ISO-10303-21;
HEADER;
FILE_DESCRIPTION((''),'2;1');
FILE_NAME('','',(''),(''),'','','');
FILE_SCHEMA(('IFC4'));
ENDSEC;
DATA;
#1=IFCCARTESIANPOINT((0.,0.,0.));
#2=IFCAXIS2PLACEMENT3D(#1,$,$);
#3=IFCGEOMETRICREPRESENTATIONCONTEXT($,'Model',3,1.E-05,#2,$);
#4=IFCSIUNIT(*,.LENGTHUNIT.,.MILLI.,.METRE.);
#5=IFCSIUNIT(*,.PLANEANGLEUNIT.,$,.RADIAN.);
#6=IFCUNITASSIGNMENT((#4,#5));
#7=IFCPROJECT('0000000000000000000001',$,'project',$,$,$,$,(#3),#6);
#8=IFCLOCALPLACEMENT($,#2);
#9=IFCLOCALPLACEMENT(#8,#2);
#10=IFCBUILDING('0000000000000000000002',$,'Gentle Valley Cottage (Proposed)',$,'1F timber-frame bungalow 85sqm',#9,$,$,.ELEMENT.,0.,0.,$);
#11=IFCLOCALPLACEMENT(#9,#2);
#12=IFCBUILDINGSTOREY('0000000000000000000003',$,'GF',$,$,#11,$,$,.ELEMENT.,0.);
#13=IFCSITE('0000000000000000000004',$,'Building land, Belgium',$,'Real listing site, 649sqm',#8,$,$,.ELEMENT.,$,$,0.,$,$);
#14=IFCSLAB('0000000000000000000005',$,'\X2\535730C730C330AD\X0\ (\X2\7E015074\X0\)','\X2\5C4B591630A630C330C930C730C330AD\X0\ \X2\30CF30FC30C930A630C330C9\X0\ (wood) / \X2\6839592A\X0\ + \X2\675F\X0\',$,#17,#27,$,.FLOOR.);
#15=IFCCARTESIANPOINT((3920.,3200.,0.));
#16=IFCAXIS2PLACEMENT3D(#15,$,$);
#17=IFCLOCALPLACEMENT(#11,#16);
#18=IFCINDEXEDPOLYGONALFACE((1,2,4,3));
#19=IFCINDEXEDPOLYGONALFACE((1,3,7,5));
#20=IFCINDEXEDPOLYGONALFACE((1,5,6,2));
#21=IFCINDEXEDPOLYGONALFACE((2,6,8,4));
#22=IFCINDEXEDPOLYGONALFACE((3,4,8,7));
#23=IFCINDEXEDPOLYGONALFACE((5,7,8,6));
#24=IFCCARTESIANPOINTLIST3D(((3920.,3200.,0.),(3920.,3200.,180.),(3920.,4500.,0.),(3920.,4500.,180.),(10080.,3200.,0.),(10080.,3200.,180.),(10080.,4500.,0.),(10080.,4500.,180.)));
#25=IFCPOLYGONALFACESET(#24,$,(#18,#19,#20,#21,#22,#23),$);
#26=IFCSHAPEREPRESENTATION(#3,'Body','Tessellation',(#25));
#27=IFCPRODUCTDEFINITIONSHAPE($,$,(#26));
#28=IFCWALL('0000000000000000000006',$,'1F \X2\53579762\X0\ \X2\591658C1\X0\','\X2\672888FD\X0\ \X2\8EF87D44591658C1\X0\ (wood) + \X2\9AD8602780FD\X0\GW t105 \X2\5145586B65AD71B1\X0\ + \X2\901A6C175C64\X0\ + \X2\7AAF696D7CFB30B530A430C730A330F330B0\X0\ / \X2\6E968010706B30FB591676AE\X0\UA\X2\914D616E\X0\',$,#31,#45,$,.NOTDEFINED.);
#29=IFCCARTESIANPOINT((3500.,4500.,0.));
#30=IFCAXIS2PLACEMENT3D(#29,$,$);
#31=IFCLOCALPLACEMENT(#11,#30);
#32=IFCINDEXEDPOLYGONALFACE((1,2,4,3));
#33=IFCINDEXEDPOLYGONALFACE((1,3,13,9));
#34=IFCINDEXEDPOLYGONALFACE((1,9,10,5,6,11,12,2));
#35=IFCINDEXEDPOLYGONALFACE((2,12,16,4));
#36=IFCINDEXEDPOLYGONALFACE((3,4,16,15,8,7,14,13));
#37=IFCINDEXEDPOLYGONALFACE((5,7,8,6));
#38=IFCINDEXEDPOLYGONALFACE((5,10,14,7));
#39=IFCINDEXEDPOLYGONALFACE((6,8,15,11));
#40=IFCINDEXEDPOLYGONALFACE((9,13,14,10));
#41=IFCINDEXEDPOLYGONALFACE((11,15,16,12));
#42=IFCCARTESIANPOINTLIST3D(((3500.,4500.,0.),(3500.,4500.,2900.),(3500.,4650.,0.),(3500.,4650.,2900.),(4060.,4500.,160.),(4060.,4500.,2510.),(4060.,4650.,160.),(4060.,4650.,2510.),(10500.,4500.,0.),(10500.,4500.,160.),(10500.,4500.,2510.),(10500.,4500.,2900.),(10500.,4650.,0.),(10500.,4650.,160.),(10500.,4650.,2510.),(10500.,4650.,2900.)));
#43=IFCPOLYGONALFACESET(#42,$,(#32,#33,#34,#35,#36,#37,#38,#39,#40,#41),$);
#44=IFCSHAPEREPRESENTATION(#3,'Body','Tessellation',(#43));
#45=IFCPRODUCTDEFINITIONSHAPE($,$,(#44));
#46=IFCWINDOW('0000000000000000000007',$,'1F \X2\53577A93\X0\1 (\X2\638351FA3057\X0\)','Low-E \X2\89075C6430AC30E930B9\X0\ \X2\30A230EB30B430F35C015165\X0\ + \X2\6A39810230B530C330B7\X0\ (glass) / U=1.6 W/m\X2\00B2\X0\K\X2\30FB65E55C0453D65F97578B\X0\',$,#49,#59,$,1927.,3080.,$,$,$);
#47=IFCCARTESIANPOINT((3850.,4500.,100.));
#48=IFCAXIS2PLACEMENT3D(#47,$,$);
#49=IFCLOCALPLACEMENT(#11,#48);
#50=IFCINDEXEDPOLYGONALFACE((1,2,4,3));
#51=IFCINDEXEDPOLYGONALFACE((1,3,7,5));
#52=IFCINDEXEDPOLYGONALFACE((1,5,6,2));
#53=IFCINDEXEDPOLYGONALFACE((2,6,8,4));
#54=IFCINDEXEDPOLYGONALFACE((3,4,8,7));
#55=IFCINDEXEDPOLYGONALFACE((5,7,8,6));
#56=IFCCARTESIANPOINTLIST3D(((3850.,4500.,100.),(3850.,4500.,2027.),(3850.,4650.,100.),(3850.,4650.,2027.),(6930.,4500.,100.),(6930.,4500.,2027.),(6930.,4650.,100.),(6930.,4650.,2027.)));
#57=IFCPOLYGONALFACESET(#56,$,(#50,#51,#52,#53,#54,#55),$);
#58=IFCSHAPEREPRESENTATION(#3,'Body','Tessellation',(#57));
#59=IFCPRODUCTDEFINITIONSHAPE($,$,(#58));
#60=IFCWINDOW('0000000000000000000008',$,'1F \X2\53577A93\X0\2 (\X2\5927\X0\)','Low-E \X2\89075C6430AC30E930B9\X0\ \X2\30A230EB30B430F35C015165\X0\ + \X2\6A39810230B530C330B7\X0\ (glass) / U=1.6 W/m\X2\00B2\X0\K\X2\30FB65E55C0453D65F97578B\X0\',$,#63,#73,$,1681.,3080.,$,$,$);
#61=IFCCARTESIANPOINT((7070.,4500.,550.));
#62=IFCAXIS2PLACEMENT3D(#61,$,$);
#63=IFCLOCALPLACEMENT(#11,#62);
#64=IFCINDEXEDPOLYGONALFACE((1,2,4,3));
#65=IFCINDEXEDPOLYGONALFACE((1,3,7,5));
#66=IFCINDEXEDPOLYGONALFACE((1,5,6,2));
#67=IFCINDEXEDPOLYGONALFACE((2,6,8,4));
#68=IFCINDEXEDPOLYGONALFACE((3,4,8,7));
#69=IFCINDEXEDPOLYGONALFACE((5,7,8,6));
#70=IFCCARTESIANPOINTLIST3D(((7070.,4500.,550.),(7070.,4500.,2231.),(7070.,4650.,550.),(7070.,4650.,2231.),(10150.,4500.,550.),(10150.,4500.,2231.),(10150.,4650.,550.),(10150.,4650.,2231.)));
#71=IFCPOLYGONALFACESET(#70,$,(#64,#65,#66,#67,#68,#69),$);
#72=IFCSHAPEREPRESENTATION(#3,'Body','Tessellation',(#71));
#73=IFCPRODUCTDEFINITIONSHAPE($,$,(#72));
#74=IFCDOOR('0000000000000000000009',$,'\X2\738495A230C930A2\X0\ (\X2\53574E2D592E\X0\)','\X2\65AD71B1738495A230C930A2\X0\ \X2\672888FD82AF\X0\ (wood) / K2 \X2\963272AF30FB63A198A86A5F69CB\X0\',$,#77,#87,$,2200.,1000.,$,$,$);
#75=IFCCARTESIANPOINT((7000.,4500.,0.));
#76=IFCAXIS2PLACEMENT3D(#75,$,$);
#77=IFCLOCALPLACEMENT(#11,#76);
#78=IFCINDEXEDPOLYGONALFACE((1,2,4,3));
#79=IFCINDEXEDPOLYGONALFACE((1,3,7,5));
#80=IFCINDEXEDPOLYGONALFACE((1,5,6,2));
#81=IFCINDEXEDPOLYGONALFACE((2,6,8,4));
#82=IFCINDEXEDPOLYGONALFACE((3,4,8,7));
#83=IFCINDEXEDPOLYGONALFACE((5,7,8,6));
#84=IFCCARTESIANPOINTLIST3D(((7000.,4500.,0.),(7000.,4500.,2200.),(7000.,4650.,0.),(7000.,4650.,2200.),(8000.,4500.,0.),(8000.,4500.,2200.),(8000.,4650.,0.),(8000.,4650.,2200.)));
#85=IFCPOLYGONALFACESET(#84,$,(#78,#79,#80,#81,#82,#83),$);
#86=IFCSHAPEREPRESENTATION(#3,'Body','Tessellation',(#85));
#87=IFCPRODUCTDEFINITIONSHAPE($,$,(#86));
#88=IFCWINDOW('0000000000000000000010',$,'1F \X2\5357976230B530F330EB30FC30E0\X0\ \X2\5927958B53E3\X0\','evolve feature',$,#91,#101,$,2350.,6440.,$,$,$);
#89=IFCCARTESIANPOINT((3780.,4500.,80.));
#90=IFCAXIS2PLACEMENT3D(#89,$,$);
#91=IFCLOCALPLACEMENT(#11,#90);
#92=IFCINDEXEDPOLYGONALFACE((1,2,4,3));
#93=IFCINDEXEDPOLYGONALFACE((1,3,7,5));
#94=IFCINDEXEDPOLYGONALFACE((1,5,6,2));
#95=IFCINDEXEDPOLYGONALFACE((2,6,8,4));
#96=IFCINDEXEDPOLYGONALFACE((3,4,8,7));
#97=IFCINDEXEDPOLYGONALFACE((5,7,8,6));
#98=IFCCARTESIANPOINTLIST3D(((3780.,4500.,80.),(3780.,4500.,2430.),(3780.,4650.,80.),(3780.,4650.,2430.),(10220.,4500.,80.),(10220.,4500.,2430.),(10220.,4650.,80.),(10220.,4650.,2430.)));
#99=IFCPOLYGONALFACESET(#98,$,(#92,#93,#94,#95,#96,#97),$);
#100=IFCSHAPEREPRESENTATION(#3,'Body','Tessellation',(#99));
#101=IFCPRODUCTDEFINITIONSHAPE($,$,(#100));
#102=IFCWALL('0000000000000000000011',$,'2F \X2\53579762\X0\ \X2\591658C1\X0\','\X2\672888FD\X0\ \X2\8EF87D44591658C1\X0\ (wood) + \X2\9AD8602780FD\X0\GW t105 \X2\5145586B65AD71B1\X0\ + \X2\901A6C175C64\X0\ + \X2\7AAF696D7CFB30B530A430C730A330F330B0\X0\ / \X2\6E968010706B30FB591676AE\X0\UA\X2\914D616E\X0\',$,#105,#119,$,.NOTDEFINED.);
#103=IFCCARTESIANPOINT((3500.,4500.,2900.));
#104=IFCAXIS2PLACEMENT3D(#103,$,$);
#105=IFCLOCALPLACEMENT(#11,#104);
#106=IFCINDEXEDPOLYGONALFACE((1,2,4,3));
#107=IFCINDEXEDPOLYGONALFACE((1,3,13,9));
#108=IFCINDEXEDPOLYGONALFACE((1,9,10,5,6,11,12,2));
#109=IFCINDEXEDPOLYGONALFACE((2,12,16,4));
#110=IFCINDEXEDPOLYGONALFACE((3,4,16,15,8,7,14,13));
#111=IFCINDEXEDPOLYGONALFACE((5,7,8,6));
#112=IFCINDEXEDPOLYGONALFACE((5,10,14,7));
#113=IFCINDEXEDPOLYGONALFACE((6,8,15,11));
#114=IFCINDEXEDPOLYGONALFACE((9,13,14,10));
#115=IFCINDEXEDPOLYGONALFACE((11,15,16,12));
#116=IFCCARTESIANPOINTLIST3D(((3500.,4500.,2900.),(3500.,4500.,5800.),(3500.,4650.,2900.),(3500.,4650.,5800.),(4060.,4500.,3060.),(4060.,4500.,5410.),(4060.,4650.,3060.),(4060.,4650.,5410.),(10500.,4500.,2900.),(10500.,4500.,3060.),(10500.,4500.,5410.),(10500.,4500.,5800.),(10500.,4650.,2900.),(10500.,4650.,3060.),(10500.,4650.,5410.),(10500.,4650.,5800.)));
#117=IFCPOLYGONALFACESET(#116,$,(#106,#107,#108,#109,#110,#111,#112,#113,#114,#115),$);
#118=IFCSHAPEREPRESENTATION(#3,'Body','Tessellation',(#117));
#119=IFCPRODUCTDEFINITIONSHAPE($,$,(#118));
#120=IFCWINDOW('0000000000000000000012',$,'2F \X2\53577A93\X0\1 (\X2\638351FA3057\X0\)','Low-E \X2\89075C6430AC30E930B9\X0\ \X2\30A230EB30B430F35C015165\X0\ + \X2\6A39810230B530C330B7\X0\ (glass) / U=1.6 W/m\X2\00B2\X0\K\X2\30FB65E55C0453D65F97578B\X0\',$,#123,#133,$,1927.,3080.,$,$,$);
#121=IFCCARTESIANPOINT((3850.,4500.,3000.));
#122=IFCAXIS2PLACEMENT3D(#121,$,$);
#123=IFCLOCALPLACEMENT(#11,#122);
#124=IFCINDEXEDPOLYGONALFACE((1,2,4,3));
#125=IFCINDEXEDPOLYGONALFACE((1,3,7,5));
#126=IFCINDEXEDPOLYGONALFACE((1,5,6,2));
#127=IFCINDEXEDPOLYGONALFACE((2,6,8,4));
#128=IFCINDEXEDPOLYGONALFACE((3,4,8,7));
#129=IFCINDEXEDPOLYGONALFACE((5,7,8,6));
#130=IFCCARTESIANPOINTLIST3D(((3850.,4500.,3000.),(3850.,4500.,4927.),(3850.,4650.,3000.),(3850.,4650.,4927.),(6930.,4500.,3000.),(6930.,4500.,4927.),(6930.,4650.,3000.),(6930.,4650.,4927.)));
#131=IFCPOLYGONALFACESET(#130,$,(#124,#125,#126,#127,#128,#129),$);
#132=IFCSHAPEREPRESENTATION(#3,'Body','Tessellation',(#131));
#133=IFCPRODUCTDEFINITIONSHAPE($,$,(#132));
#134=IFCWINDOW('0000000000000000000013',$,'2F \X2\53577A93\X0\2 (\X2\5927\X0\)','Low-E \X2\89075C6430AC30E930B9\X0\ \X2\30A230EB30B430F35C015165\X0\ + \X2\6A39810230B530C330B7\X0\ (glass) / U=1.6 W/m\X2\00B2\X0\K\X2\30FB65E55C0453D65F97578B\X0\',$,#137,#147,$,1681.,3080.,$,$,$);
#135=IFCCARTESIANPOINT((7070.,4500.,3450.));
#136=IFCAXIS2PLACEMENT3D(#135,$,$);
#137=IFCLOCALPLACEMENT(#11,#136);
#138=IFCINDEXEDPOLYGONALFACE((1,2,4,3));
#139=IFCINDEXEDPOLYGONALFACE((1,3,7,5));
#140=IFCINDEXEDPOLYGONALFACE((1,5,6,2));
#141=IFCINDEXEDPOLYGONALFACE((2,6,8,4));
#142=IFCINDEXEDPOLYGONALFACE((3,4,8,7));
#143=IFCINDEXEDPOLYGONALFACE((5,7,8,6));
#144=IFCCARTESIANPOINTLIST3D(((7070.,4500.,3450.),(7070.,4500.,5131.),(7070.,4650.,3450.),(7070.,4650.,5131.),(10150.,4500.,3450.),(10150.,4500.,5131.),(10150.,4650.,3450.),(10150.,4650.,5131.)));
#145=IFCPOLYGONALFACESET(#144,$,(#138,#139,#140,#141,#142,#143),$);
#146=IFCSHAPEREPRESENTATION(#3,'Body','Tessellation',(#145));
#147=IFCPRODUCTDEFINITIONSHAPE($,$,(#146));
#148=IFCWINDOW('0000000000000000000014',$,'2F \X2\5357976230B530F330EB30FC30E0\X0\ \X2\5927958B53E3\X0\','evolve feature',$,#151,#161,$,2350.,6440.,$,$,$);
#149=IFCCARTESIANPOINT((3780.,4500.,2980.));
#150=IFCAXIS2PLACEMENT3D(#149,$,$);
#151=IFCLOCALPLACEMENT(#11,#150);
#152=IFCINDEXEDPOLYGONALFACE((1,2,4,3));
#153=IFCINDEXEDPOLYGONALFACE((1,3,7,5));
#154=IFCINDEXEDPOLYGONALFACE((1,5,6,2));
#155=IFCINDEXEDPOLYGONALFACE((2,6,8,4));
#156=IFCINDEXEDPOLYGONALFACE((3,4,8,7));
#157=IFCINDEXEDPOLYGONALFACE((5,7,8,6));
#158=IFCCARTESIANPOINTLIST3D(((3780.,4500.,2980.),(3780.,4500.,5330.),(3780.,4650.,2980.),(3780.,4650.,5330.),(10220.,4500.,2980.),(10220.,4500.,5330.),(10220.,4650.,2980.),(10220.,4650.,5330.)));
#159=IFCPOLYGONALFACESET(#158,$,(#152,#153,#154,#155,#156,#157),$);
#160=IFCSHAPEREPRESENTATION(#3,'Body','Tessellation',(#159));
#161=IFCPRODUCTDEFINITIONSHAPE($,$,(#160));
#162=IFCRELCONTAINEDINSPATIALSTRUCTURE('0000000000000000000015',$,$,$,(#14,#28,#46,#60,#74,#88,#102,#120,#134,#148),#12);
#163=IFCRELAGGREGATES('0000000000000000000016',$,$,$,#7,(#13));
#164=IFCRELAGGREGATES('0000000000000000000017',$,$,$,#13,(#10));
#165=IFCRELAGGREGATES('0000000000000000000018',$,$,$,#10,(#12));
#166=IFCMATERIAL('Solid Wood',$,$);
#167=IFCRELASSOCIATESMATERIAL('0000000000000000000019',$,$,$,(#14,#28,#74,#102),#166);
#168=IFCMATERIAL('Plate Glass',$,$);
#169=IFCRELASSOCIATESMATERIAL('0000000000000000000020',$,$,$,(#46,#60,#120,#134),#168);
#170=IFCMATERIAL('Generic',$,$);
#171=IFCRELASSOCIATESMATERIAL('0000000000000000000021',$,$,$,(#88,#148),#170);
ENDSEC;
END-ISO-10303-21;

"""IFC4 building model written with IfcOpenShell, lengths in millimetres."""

from ifc_helpers import new_model, si_unit, frame, frame_2d, origin, place, context, project, spatial, rectangle, extrude, material, element, fill, save


model = new_model("IFC4")

# Units and contexts
model_context = context("Model", 3, precision=1e-05, world=origin())
ifc_project = project(units=[si_unit("LENGTHUNIT", "METRE", prefix="MILLI"), si_unit("PLANEANGLEUNIT", "RADIAN")], contexts=[model_context])

# Site, building, storey
site_placement = place(None, origin())
site = spatial("IfcSite", under=ifc_project, at=site_placement, Name="Building land, Belgium", ObjectType="Real listing site, 649sqm", CompositionType="ELEMENT", RefElevation=0.0)
building_placement = place(site_placement, origin())
building = spatial("IfcBuilding", under=site, at=building_placement, Name="Gentle Valley Cottage (Proposed)", ObjectType="1F timber-frame bungalow 85sqm", CompositionType="ELEMENT", ElevationOfRefHeight=0.0, ElevationOfTerrain=0.0)
storey_placement = place(building_placement, origin())
storey = spatial("IfcBuildingStorey", under=building, at=storey_placement, Name="GF", CompositionType="ELEMENT", Elevation=0.0)

# Slab
ifc_material_1 = material(Name="Solid Wood")
slab_1_placement = place(storey_placement, frame((3920.0, 3200.0, 0.0)))
element("IfcSlab", 1, at=slab_1_placement, inside=storey, material=ifc_material_1, Name="南デッキ (縁側)", Description="屋外ウッドデッキ ハードウッド (wood) / 根太 + 束", PredefinedType="FLOOR", context=model_context, shape_type="SweptSolid", body=[
    extrude(rectangle(XDim=6160.0, YDim=1300.0, at=frame_2d((3080.0, 650.0))), frame((3920.0, 3200.0, 0.0)), (0.0, 0.0, 1.0), 180.0),
])
ifc_material_2 = material(Name="Generic")

# Wall, openings, windows, door
wall_1_placement = place(storey_placement, frame((3500.0, 4500.0, 0.0)))
wall_1 = element("IfcWall", 2, at=wall_1_placement, inside=storey, material=ifc_material_1, Name="1F 南面 外壁", Description="木製 軸組外壁 (wood) + 高性能GW t105 充填断熱 + 通気層 + 窯業系サイディング / 準耐火・外皮UA配慮", PredefinedType="NOTDEFINED", context=model_context, shape_type="SweptSolid", body=[
    extrude(rectangle(XDim=7000.0, YDim=150.0, at=frame_2d((3500.0, 75.0))), frame((3500.0, 4500.0, 0.0)), (0.0, 0.0, 1.0), 2900.0),
])
opening_1_placement = place(storey_placement, frame((3850.0, 4500.0, 100.0)))
opening_1 = element("IfcOpeningElement", 3, at=opening_1_placement, cuts=wall_1, PredefinedType="NOTDEFINED", context=model_context, shape_type="SweptSolid", body=[
    extrude(rectangle(XDim=3080.0, YDim=150.0, at=frame_2d((1540.0, 75.0))), frame((3850.0, 4500.0, 100.0)), (0.0, 0.0, 1.0), 1927.0),
])
opening_2_placement = place(storey_placement, frame((7070.0, 4500.0, 550.0)))
opening_2 = element("IfcOpeningElement", 4, at=opening_2_placement, cuts=wall_1, PredefinedType="NOTDEFINED", context=model_context, shape_type="SweptSolid", body=[
    extrude(rectangle(XDim=3080.0, YDim=150.0, at=frame_2d((1540.0, 75.0))), frame((7070.0, 4500.0, 550.0)), (0.0, 0.0, 1.0), 1681.0),
])
opening_3_placement = place(storey_placement, frame((7000.0, 4500.0, 0.0)))
opening_3 = element("IfcOpeningElement", 5, at=opening_3_placement, cuts=wall_1, PredefinedType="NOTDEFINED", context=model_context, shape_type="SweptSolid", body=[
    extrude(rectangle(XDim=1000.0, YDim=150.0, at=frame_2d((500.0, 75.0))), frame((7000.0, 4500.0, 0.0)), (0.0, 0.0, 1.0), 2200.0),
])
opening_4_placement = place(storey_placement, frame((3780.0, 4500.0, 80.0)))
opening_4 = element("IfcOpeningElement", 6, at=opening_4_placement, cuts=wall_1, PredefinedType="NOTDEFINED", context=model_context, shape_type="SweptSolid", body=[
    extrude(rectangle(XDim=6440.0, YDim=150.0, at=frame_2d((3220.0, 75.0))), frame((3780.0, 4500.0, 80.0)), (0.0, 0.0, 1.0), 2350.0),
])
ifc_material_3 = material(Name="Plate Glass")
window_1_placement = place(storey_placement, frame((3850.0, 4500.0, 100.0)))
window_1 = element("IfcWindow", 7, at=window_1_placement, inside=storey, material=ifc_material_3, Name="1F 南窓1 (掃出し)", Description="Low-E 複層ガラス アルゴン封入 + 樹脂サッシ (glass) / U=1.6 W/m²K・日射取得型", OverallHeight=1927.0, OverallWidth=3080.0, context=model_context, shape_type="SweptSolid", body=[
    extrude(rectangle(XDim=3080.0, YDim=150.0, at=frame_2d((1540.0, 75.0))), frame((3850.0, 4500.0, 100.0)), (0.0, 0.0, 1.0), 1927.0),
])
fill(opening_1, window_1)
window_2_placement = place(storey_placement, frame((7070.0, 4500.0, 550.0)))
window_2 = element("IfcWindow", 8, at=window_2_placement, inside=storey, material=ifc_material_3, Name="1F 南窓2 (大)", Description="Low-E 複層ガラス アルゴン封入 + 樹脂サッシ (glass) / U=1.6 W/m²K・日射取得型", OverallHeight=1681.0, OverallWidth=3080.0, context=model_context, shape_type="SweptSolid", body=[
    extrude(rectangle(XDim=3080.0, YDim=150.0, at=frame_2d((1540.0, 75.0))), frame((7070.0, 4500.0, 550.0)), (0.0, 0.0, 1.0), 1681.0),
])
fill(opening_2, window_2)
door_placement = place(storey_placement, frame((7000.0, 4500.0, 0.0)))
door = element("IfcDoor", 9, at=door_placement, inside=storey, material=ifc_material_1, Name="玄関ドア (南中央)", Description="断熱玄関ドア 木製芯 (wood) / K2 防犯・採風機構", OverallHeight=2200.0, OverallWidth=1000.0, context=model_context, shape_type="SweptSolid", body=[
    extrude(rectangle(XDim=1000.0, YDim=150.0, at=frame_2d((500.0, 75.0))), frame((7000.0, 4500.0, 0.0)), (0.0, 0.0, 1.0), 2200.0),
])
fill(opening_3, door)
window_3_placement = place(storey_placement, frame((3780.0, 4500.0, 80.0)))
window_3 = element("IfcWindow", 10, at=window_3_placement, inside=storey, material=ifc_material_2, Name="1F 南面サンルーム 大開口", Description="evolve feature", OverallHeight=2350.0, OverallWidth=6440.0, context=model_context, shape_type="SweptSolid", body=[
    extrude(rectangle(XDim=6440.0, YDim=150.0, at=frame_2d((3220.0, 75.0))), frame((3780.0, 4500.0, 80.0)), (0.0, 0.0, 1.0), 2350.0),
])
fill(opening_4, window_3)

# Wall, openings, windows
wall_2_placement = place(storey_placement, frame((3500.0, 4500.0, 2900.0)))
wall_2 = element("IfcWall", 11, at=wall_2_placement, inside=storey, material=ifc_material_1, Name="2F 南面 外壁", Description="木製 軸組外壁 (wood) + 高性能GW t105 充填断熱 + 通気層 + 窯業系サイディング / 準耐火・外皮UA配慮", PredefinedType="NOTDEFINED", context=model_context, shape_type="SweptSolid", body=[
    extrude(rectangle(XDim=7000.0, YDim=150.0, at=frame_2d((3500.0, 75.0))), frame((3500.0, 4500.0, 2900.0)), (0.0, 0.0, 1.0), 2900.0),
])
opening_5_placement = place(storey_placement, frame((3850.0, 4500.0, 3000.0)))
opening_5 = element("IfcOpeningElement", 12, at=opening_5_placement, cuts=wall_2, PredefinedType="NOTDEFINED", context=model_context, shape_type="SweptSolid", body=[
    extrude(rectangle(XDim=3080.0, YDim=150.0, at=frame_2d((1540.0, 75.0))), frame((3850.0, 4500.0, 3000.0)), (0.0, 0.0, 1.0), 1927.0),
])
opening_6_placement = place(storey_placement, frame((7070.0, 4500.0, 3450.0)))
opening_6 = element("IfcOpeningElement", 13, at=opening_6_placement, cuts=wall_2, PredefinedType="NOTDEFINED", context=model_context, shape_type="SweptSolid", body=[
    extrude(rectangle(XDim=3080.0, YDim=150.0, at=frame_2d((1540.0, 75.0))), frame((7070.0, 4500.0, 3450.0)), (0.0, 0.0, 1.0), 1681.0),
])
opening_7_placement = place(storey_placement, frame((3780.0, 4500.0, 2980.0)))
opening_7 = element("IfcOpeningElement", 14, at=opening_7_placement, cuts=wall_2, PredefinedType="NOTDEFINED", context=model_context, shape_type="SweptSolid", body=[
    extrude(rectangle(XDim=6440.0, YDim=150.0, at=frame_2d((3220.0, 75.0))), frame((3780.0, 4500.0, 2980.0)), (0.0, 0.0, 1.0), 2350.0),
])
window_4_placement = place(storey_placement, frame((3850.0, 4500.0, 3000.0)))
window_4 = element("IfcWindow", 15, at=window_4_placement, inside=storey, material=ifc_material_3, Name="2F 南窓1 (掃出し)", Description="Low-E 複層ガラス アルゴン封入 + 樹脂サッシ (glass) / U=1.6 W/m²K・日射取得型", OverallHeight=1927.0, OverallWidth=3080.0, context=model_context, shape_type="SweptSolid", body=[
    extrude(rectangle(XDim=3080.0, YDim=150.0, at=frame_2d((1540.0, 75.0))), frame((3850.0, 4500.0, 3000.0)), (0.0, 0.0, 1.0), 1927.0),
])
fill(opening_5, window_4)
window_5_placement = place(storey_placement, frame((7070.0, 4500.0, 3450.0)))
window_5 = element("IfcWindow", 16, at=window_5_placement, inside=storey, material=ifc_material_3, Name="2F 南窓2 (大)", Description="Low-E 複層ガラス アルゴン封入 + 樹脂サッシ (glass) / U=1.6 W/m²K・日射取得型", OverallHeight=1681.0, OverallWidth=3080.0, context=model_context, shape_type="SweptSolid", body=[
    extrude(rectangle(XDim=3080.0, YDim=150.0, at=frame_2d((1540.0, 75.0))), frame((7070.0, 4500.0, 3450.0)), (0.0, 0.0, 1.0), 1681.0),
])
fill(opening_6, window_5)
window_6_placement = place(storey_placement, frame((3780.0, 4500.0, 2980.0)))
window_6 = element("IfcWindow", 17, at=window_6_placement, inside=storey, material=ifc_material_2, Name="2F 南面サンルーム 大開口", Description="evolve feature", OverallHeight=2350.0, OverallWidth=6440.0, context=model_context, shape_type="SweptSolid", body=[
    extrude(rectangle(XDim=6440.0, YDim=150.0, at=frame_2d((3220.0, 75.0))), frame((3780.0, 4500.0, 2980.0)), (0.0, 0.0, 1.0), 2350.0),
])
fill(opening_7, window_6)

save(model, "model.ifc")
